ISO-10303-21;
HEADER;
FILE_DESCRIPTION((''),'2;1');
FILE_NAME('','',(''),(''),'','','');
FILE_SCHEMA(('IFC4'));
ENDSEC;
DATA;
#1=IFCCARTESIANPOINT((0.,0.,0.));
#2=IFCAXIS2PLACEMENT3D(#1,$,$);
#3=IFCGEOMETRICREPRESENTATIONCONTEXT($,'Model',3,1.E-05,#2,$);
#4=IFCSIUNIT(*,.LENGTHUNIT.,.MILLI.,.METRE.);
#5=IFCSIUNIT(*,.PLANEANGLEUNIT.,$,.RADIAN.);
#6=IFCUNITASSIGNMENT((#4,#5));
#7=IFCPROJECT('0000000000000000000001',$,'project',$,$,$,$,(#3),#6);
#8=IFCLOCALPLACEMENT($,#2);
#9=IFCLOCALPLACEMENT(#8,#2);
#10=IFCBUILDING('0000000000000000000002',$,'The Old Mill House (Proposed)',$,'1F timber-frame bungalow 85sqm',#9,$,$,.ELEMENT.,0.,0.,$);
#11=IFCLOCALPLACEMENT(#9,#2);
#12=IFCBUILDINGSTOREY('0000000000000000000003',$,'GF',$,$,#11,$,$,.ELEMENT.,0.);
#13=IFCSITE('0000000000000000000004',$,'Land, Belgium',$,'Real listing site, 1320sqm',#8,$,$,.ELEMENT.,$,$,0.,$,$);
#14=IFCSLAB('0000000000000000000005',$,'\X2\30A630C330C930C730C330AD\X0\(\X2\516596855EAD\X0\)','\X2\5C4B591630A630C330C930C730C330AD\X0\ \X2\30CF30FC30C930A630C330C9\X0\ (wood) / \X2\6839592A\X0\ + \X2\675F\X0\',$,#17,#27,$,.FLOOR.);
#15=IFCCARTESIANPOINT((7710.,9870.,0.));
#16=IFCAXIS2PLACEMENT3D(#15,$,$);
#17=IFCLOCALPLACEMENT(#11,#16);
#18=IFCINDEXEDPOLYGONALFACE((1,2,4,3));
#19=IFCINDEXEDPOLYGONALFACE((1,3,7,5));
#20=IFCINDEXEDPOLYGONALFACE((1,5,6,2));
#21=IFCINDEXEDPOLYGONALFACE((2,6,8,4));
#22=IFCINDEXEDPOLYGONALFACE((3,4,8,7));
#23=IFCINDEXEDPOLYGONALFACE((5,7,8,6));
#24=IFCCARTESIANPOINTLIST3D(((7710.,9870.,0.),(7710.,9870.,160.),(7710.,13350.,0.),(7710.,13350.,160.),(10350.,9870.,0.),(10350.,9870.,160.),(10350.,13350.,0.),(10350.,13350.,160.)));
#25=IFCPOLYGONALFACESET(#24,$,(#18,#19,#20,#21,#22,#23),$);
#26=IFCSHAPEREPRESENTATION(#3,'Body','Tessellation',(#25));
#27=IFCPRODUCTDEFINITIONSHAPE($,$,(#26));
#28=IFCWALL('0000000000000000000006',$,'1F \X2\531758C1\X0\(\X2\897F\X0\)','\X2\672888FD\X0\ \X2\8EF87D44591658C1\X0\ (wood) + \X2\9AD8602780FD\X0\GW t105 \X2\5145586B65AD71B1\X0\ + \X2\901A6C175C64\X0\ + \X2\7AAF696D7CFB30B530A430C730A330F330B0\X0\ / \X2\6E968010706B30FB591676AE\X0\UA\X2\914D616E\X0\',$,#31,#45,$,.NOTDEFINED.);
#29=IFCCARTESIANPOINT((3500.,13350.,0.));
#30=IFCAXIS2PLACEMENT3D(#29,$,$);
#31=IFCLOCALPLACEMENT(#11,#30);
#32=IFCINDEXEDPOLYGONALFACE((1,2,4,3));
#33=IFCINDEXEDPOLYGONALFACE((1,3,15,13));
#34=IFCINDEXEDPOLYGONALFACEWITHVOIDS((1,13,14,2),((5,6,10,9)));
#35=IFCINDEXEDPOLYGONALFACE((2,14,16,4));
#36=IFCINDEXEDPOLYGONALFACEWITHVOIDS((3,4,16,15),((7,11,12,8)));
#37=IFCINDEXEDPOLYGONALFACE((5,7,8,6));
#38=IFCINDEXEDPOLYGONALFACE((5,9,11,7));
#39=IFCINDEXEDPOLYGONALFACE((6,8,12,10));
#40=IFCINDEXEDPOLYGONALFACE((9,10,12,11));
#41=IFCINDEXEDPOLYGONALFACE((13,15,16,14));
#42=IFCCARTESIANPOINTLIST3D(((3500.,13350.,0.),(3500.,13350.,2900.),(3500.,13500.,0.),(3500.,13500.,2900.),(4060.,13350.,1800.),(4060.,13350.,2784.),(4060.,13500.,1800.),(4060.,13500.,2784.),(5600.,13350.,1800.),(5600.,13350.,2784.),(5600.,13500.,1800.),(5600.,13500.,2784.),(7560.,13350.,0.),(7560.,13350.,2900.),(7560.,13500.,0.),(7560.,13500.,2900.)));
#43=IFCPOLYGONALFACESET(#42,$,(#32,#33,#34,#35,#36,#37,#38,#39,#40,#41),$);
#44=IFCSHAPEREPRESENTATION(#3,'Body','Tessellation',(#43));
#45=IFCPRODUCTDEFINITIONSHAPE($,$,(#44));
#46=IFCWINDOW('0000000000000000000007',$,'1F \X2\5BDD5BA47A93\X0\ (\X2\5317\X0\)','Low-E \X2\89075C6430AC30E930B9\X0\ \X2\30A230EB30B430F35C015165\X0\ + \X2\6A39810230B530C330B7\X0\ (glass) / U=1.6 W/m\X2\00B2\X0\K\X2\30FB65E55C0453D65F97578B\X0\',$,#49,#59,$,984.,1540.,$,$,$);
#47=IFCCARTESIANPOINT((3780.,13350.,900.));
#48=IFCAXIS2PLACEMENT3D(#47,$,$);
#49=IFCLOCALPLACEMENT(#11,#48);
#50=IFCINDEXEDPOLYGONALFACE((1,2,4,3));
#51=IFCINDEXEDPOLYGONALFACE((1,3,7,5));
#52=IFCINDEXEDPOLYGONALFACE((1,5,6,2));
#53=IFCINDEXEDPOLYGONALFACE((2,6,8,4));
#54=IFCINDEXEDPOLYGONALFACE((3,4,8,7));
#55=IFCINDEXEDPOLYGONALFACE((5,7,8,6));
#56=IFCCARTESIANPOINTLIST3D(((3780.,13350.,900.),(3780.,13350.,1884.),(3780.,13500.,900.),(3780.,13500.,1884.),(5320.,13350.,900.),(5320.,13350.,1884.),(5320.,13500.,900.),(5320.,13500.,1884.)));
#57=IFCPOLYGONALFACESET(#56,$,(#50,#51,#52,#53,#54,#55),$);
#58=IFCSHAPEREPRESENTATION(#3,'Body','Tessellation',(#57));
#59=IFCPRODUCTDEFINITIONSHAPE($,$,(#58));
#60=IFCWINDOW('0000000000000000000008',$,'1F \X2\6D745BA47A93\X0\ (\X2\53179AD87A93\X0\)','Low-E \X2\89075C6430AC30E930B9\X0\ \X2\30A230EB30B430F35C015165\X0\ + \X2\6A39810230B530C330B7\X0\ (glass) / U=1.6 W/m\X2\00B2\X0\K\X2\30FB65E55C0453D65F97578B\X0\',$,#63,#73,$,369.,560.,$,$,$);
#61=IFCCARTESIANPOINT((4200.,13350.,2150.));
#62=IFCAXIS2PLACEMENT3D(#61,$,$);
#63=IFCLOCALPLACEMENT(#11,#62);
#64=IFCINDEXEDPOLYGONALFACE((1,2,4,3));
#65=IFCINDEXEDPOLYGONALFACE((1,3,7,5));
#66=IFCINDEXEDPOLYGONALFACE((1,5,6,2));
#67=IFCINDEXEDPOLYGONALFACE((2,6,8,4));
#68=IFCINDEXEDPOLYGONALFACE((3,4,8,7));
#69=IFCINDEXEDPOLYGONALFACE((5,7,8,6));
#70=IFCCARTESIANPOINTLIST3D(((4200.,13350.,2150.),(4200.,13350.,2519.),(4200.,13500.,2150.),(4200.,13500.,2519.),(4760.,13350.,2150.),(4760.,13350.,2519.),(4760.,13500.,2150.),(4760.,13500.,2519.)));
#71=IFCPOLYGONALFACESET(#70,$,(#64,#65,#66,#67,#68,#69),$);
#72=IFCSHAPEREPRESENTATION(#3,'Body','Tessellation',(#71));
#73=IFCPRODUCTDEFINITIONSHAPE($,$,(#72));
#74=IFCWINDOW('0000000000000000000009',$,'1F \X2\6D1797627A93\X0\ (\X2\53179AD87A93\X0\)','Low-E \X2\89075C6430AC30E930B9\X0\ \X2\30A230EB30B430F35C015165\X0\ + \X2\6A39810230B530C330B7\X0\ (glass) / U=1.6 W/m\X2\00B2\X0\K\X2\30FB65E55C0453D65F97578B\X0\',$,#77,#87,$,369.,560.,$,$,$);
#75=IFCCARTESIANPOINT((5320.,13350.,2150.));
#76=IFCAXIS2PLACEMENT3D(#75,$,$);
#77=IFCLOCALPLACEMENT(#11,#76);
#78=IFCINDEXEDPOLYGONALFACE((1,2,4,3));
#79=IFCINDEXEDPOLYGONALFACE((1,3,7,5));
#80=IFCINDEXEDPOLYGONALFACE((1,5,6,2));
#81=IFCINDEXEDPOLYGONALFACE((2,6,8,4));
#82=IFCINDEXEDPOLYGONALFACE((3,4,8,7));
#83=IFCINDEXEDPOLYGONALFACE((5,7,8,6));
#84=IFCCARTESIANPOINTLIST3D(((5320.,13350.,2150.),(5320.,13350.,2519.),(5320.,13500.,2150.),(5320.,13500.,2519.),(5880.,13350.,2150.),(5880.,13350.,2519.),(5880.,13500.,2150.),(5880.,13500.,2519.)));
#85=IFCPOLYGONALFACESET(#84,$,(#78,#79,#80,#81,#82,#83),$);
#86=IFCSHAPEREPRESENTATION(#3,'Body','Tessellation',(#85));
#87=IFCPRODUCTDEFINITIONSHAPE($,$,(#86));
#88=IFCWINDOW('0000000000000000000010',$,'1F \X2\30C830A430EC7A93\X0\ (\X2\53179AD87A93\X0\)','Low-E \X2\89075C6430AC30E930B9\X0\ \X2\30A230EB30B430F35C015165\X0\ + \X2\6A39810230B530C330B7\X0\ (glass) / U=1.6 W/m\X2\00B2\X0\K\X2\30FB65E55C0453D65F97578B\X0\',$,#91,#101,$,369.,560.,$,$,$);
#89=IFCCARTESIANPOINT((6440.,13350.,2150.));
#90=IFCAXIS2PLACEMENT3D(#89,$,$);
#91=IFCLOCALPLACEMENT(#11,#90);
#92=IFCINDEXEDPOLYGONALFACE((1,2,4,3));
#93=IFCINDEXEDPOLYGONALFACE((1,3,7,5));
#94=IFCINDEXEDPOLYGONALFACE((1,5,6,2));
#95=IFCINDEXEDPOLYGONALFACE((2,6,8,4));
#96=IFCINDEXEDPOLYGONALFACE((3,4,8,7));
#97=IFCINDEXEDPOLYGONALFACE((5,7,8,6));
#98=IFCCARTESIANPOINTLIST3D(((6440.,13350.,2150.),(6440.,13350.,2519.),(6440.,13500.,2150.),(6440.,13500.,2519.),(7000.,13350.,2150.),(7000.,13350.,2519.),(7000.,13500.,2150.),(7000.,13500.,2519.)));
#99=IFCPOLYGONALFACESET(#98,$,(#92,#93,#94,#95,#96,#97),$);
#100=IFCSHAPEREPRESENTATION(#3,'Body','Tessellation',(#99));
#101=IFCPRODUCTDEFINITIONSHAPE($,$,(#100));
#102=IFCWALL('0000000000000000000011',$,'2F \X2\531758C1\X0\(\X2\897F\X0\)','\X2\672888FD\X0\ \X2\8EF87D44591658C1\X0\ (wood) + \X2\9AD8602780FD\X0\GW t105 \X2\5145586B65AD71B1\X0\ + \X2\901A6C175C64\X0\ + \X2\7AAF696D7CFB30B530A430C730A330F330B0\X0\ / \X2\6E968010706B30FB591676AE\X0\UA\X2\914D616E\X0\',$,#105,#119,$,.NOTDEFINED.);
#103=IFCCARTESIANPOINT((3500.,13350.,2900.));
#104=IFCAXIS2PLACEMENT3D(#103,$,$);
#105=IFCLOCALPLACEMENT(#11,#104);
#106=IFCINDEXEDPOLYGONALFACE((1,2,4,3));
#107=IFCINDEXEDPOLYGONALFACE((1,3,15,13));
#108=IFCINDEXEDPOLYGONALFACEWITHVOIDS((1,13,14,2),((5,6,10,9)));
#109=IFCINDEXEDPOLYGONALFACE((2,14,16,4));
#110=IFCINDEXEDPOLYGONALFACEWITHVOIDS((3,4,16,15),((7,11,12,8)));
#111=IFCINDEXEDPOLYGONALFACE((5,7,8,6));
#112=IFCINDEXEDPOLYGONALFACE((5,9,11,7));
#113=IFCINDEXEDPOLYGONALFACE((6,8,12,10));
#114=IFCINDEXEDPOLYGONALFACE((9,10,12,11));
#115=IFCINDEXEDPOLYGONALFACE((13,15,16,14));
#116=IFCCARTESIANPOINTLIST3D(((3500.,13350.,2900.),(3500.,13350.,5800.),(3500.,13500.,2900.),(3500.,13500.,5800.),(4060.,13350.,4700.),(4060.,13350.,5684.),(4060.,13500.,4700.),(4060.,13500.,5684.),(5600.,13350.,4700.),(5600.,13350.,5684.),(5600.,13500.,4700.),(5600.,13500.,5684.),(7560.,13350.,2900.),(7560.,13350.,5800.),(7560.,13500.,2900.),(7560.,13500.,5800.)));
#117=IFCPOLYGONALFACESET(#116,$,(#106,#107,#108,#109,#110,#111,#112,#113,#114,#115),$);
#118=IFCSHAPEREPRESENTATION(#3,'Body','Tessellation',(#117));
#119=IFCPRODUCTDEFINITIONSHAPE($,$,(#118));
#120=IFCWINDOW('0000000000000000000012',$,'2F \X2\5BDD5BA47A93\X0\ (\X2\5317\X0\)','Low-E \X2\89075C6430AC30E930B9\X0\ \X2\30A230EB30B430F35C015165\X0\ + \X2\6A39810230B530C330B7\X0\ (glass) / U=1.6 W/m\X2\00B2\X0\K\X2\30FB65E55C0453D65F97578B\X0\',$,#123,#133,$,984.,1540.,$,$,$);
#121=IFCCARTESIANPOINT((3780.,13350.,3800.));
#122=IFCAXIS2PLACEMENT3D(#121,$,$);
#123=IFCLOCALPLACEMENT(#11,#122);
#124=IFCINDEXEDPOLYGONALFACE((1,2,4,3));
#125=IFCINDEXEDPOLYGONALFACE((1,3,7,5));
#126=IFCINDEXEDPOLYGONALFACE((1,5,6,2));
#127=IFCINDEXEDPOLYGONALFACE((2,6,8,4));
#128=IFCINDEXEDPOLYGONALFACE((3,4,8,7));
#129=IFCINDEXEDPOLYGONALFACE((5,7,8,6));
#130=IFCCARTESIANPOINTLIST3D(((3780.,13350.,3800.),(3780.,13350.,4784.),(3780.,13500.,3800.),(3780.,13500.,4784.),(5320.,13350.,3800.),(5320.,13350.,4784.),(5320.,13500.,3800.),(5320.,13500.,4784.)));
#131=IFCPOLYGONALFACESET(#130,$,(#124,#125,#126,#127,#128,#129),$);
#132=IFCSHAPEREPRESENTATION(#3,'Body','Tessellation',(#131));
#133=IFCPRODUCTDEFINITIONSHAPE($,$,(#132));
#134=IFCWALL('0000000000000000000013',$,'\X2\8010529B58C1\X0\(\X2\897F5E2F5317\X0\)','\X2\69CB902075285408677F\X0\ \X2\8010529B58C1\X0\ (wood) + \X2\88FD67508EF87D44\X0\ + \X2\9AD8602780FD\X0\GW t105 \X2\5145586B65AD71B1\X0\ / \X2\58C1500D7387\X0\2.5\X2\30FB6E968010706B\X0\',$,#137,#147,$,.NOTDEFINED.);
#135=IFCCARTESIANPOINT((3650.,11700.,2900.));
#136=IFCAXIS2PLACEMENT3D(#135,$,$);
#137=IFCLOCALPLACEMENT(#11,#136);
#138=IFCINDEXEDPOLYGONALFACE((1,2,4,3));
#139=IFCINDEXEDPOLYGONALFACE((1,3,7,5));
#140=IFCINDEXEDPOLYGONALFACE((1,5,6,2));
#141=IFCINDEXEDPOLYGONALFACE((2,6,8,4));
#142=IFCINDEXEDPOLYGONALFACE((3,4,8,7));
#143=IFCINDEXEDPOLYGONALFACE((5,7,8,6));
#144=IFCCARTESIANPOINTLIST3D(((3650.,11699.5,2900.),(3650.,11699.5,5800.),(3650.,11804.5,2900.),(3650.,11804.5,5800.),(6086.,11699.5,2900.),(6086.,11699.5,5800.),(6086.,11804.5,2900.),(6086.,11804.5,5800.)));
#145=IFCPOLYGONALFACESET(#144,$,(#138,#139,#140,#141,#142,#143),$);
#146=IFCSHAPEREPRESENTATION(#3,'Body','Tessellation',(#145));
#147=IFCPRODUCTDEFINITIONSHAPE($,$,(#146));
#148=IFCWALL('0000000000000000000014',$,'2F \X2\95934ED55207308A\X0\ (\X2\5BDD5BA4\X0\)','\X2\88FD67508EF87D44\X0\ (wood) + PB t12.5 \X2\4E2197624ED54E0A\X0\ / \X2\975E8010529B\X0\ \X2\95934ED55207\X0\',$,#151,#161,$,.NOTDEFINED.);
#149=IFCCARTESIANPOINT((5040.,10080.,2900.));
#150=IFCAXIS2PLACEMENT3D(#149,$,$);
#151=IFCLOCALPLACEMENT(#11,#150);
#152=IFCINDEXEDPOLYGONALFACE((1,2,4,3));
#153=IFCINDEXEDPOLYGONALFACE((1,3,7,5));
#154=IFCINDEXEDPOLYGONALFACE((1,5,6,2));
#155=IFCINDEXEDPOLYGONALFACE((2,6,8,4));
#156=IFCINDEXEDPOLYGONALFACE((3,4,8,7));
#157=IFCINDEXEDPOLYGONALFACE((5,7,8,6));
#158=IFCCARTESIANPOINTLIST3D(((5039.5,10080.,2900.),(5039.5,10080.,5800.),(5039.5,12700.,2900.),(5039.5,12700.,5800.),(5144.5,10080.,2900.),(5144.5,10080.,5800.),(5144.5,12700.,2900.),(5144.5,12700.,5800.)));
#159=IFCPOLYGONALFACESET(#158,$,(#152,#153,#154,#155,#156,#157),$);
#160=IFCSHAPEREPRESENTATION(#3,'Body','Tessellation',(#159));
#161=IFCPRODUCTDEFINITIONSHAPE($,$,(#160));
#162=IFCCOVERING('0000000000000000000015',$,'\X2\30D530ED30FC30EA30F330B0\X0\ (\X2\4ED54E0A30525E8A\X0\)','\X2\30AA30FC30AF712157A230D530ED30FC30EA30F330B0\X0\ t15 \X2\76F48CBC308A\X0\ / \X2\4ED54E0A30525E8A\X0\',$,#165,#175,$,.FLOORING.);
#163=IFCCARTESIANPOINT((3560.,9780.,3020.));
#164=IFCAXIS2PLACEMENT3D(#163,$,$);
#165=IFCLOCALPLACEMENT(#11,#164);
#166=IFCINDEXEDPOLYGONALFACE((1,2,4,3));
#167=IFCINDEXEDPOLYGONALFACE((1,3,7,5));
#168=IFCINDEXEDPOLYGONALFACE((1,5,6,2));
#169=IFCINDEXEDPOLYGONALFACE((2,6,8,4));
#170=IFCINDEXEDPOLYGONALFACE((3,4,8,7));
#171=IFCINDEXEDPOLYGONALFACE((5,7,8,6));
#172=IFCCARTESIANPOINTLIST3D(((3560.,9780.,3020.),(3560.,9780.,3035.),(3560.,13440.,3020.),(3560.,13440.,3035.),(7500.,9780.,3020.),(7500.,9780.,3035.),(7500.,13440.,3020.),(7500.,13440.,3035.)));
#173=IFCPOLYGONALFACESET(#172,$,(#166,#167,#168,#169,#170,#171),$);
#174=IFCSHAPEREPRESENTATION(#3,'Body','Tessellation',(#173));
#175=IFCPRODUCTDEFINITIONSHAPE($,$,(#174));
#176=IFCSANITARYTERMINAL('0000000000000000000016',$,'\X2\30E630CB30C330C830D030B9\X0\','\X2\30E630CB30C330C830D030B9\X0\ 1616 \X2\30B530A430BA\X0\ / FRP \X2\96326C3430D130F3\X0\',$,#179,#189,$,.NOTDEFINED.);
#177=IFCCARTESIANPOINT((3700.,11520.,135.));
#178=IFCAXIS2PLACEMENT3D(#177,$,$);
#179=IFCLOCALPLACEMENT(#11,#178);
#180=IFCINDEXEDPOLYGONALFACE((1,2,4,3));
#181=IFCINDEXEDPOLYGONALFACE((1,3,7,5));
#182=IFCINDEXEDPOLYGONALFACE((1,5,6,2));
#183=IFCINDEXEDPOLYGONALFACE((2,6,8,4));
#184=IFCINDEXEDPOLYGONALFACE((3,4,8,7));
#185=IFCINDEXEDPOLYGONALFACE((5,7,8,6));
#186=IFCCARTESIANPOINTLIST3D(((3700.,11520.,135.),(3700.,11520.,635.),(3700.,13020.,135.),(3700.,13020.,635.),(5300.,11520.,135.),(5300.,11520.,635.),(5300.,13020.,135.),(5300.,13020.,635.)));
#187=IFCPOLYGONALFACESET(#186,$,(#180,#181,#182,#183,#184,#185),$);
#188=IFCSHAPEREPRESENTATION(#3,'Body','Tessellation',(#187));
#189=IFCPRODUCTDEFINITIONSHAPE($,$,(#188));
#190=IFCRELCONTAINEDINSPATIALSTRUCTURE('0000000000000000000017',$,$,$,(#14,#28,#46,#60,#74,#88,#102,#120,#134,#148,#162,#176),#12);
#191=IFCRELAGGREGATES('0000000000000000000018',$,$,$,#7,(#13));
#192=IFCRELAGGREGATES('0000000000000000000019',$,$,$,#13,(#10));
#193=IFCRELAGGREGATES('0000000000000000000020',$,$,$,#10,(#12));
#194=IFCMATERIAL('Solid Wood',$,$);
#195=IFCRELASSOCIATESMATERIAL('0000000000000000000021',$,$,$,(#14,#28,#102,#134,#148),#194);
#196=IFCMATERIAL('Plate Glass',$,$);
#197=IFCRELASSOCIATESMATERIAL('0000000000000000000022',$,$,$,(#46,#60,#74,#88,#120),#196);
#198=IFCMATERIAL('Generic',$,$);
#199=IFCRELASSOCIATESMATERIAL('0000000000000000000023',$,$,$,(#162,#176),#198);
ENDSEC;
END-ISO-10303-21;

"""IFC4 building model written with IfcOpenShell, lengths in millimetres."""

from ifc_helpers import new_model, si_unit, frame, frame_2d, origin, place, context, project, spatial, rectangle, extrude, material, element, fill, save


model = new_model("IFC4")

# Units and contexts
model_context = context("Model", 3, precision=1e-05, world=origin())
ifc_project = project(units=[si_unit("LENGTHUNIT", "METRE", prefix="MILLI"), si_unit("PLANEANGLEUNIT", "RADIAN")], contexts=[model_context])

# Site, building, storey
site_placement = place(None, origin())
site = spatial("IfcSite", under=ifc_project, at=site_placement, Name="Land, Belgium", ObjectType="Real listing site, 1320sqm", CompositionType="ELEMENT", RefElevation=0.0)
building_placement = place(site_placement, origin())
building = spatial("IfcBuilding", under=site, at=building_placement, Name="The Old Mill House (Proposed)", ObjectType="1F timber-frame bungalow 85sqm", CompositionType="ELEMENT", ElevationOfRefHeight=0.0, ElevationOfTerrain=0.0)
storey_placement = place(building_placement, origin())
storey = spatial("IfcBuildingStorey", under=building, at=storey_placement, Name="GF", CompositionType="ELEMENT", Elevation=0.0)

# Slab
ifc_material_1 = material(Name="Solid Wood")
slab_placement = place(storey_placement, frame((7710.0, 9870.0, 0.0)))
element("IfcSlab", 1, at=slab_placement, inside=storey, material=ifc_material_1, Name="ウッドデッキ(入隅庭)", Description="屋外ウッドデッキ ハードウッド (wood) / 根太 + 束", PredefinedType="FLOOR", context=model_context, shape_type="SweptSolid", body=[
    extrude(rectangle(XDim=2640.0, YDim=3480.0, at=frame_2d((1320.0, 1740.0))), frame((7710.0, 9870.0, 0.0)), (0.0, 0.0, 1.0), 160.0),
])

# Wall, openings, windows
wall_1_placement = place(storey_placement, frame((3500.0, 13350.0, 0.0)))
wall_1 = element("IfcWall", 2, at=wall_1_placement, inside=storey, material=ifc_material_1, Name="1F 北壁(西)", Description="木製 軸組外壁 (wood) + 高性能GW t105 充填断熱 + 通気層 + 窯業系サイディング / 準耐火・外皮UA配慮", PredefinedType="NOTDEFINED", context=model_context, shape_type="SweptSolid", body=[
    extrude(rectangle(XDim=4060.0, YDim=150.0, at=frame_2d((2030.0, 75.0))), frame((3500.0, 13350.0, 0.0)), (0.0, 0.0, 1.0), 2900.0),
])
opening_1_placement = place(storey_placement, frame((3780.0, 13350.0, 900.0)))
opening_1 = element("IfcOpeningElement", 3, at=opening_1_placement, cuts=wall_1, PredefinedType="NOTDEFINED", context=model_context, shape_type="SweptSolid", body=[
    extrude(rectangle(XDim=1540.0, YDim=150.0, at=frame_2d((770.0, 75.0))), frame((3780.0, 13350.0, 900.0)), (0.0, 0.0, 1.0), 984.0),
])
opening_2_placement = place(storey_placement, frame((4200.0, 13350.0, 2150.0)))
opening_2 = element("IfcOpeningElement", 4, at=opening_2_placement, cuts=wall_1, PredefinedType="NOTDEFINED", context=model_context, shape_type="SweptSolid", body=[
    extrude(rectangle(XDim=560.0, YDim=150.0, at=frame_2d((280.0, 75.0))), frame((4200.0, 13350.0, 2150.0)), (0.0, 0.0, 1.0), 369.0),
])
opening_3_placement = place(storey_placement, frame((5320.0, 13350.0, 2150.0)))
opening_3 = element("IfcOpeningElement", 5, at=opening_3_placement, cuts=wall_1, PredefinedType="NOTDEFINED", context=model_context, shape_type="SweptSolid", body=[
    extrude(rectangle(XDim=560.0, YDim=150.0, at=frame_2d((280.0, 75.0))), frame((5320.0, 13350.0, 2150.0)), (0.0, 0.0, 1.0), 369.0),
])
opening_4_placement = place(storey_placement, frame((6440.0, 13350.0, 2150.0)))
opening_4 = element("IfcOpeningElement", 6, at=opening_4_placement, cuts=wall_1, PredefinedType="NOTDEFINED", context=model_context, shape_type="SweptSolid", body=[
    extrude(rectangle(XDim=560.0, YDim=150.0, at=frame_2d((280.0, 75.0))), frame((6440.0, 13350.0, 2150.0)), (0.0, 0.0, 1.0), 369.0),
])
ifc_material_2 = material(Name="Plate Glass")
window_1_placement = place(storey_placement, frame((3780.0, 13350.0, 900.0)))
window_1 = element("IfcWindow", 7, at=window_1_placement, inside=storey, material=ifc_material_2, Name="1F 寝室窓 (北)", Description="Low-E 複層ガラス アルゴン封入 + 樹脂サッシ (glass) / U=1.6 W/m²K・日射取得型", OverallHeight=984.0, OverallWidth=1540.0, context=model_context, shape_type="SweptSolid", body=[
    extrude(rectangle(XDim=1540.0, YDim=150.0, at=frame_2d((770.0, 75.0))), frame((3780.0, 13350.0, 900.0)), (0.0, 0.0, 1.0), 984.0),
])
fill(opening_1, window_1)
window_2_placement = place(storey_placement, frame((4200.0, 13350.0, 2150.0)))
window_2 = element("IfcWindow", 8, at=window_2_placement, inside=storey, material=ifc_material_2, Name="1F 浴室窓 (北高窓)", Description="Low-E 複層ガラス アルゴン封入 + 樹脂サッシ (glass) / U=1.6 W/m²K・日射取得型", OverallHeight=369.0, OverallWidth=560.0, context=model_context, shape_type="SweptSolid", body=[
    extrude(rectangle(XDim=560.0, YDim=150.0, at=frame_2d((280.0, 75.0))), frame((4200.0, 13350.0, 2150.0)), (0.0, 0.0, 1.0), 369.0),
])
fill(opening_2, window_2)
window_3_placement = place(storey_placement, frame((5320.0, 13350.0, 2150.0)))
window_3 = element("IfcWindow", 9, at=window_3_placement, inside=storey, material=ifc_material_2, Name="1F 洗面窓 (北高窓)", Description="Low-E 複層ガラス アルゴン封入 + 樹脂サッシ (glass) / U=1.6 W/m²K・日射取得型", OverallHeight=369.0, OverallWidth=560.0, context=model_context, shape_type="SweptSolid", body=[
    extrude(rectangle(XDim=560.0, YDim=150.0, at=frame_2d((280.0, 75.0))), frame((5320.0, 13350.0, 2150.0)), (0.0, 0.0, 1.0), 369.0),
])
fill(opening_3, window_3)
window_4_placement = place(storey_placement, frame((6440.0, 13350.0, 2150.0)))
window_4 = element("IfcWindow", 10, at=window_4_placement, inside=storey, material=ifc_material_2, Name="1F トイレ窓 (北高窓)", Description="Low-E 複層ガラス アルゴン封入 + 樹脂サッシ (glass) / U=1.6 W/m²K・日射取得型", OverallHeight=369.0, OverallWidth=560.0, context=model_context, shape_type="SweptSolid", body=[
    extrude(rectangle(XDim=560.0, YDim=150.0, at=frame_2d((280.0, 75.0))), frame((6440.0, 13350.0, 2150.0)), (0.0, 0.0, 1.0), 369.0),
])
fill(opening_4, window_4)

# Wall, opening, window
wall_2_placement = place(storey_placement, frame((3500.0, 13350.0, 2900.0)))
wall_2 = element("IfcWall", 11, at=wall_2_placement, inside=storey, material=ifc_material_1, Name="2F 北壁(西)", Description="木製 軸組外壁 (wood) + 高性能GW t105 充填断熱 + 通気層 + 窯業系サイディング / 準耐火・外皮UA配慮", PredefinedType="NOTDEFINED", context=model_context, shape_type="SweptSolid", body=[
    extrude(rectangle(XDim=4060.0, YDim=150.0, at=frame_2d((2030.0, 75.0))), frame((3500.0, 13350.0, 2900.0)), (0.0, 0.0, 1.0), 2900.0),
])
opening_5_placement = place(storey_placement, frame((3780.0, 13350.0, 3800.0)))
opening_5 = element("IfcOpeningElement", 12, at=opening_5_placement, cuts=wall_2, PredefinedType="NOTDEFINED", context=model_context, shape_type="SweptSolid", body=[
    extrude(rectangle(XDim=1540.0, YDim=150.0, at=frame_2d((770.0, 75.0))), frame((3780.0, 13350.0, 3800.0)), (0.0, 0.0, 1.0), 984.0),
])
window_5_placement = place(storey_placement, frame((3780.0, 13350.0, 3800.0)))
window_5 = element("IfcWindow", 13, at=window_5_placement, inside=storey, material=ifc_material_2, Name="2F 寝室窓 (北)", Description="Low-E 複層ガラス アルゴン封入 + 樹脂サッシ (glass) / U=1.6 W/m²K・日射取得型", OverallHeight=984.0, OverallWidth=1540.0, context=model_context, shape_type="SweptSolid", body=[
    extrude(rectangle(XDim=1540.0, YDim=150.0, at=frame_2d((770.0, 75.0))), frame((3780.0, 13350.0, 3800.0)), (0.0, 0.0, 1.0), 984.0),
])
fill(opening_5, window_5)

# Walls
wall_3_placement = place(storey_placement, frame((3650.0, 11700.0, 2900.0)))
element("IfcWall", 14, at=wall_3_placement, inside=storey, material=ifc_material_1, Name="耐力壁(西帯北)", Description="構造用合板 耐力壁 (wood) + 製材軸組 + 高性能GW t105 充填断熱 / 壁倍率2.5・準耐火", PredefinedType="NOTDEFINED", context=model_context, shape_type="SweptSolid", body=[
    extrude(rectangle(XDim=2436.0, YDim=105.0, at=frame_2d((1218.0, 52.0))), frame((3650.0, 11700.0, 2900.0)), (0.0, 0.0, 1.0), 2900.0),
])
wall_4_placement = place(storey_placement, frame((5040.0, 10080.0, 2900.0)))
element("IfcWall", 15, at=wall_4_placement, inside=storey, material=ifc_material_1, Name="2F 間仕切り (寝室)", Description="製材軸組 (wood) + PB t12.5 両面仕上 / 非耐力 間仕切", PredefinedType="NOTDEFINED", context=model_context, shape_type="SweptSolid", body=[
    extrude(rectangle(XDim=105.0, YDim=2620.0, at=frame_2d((52.0, 1310.0))), frame((5040.0, 10080.0, 2900.0)), (0.0, 0.0, 1.0), 2900.0),
])

# Covering
ifc_material_3 = material(Name="Generic")
covering_placement = place(storey_placement, frame((3560.0, 9780.0, 3020.0)))
element("IfcCovering", 16, at=covering_placement, inside=storey, material=ifc_material_3, Name="フローリング (仕上げ床)", Description="オーク無垢フローリング t15 直貼り / 仕上げ床", PredefinedType="FLOORING", context=model_context, shape_type="SweptSolid", body=[
    extrude(rectangle(XDim=3940.0, YDim=3660.0, at=frame_2d((1970.0, 1830.0))), frame((3560.0, 9780.0, 3020.0)), (0.0, 0.0, 1.0), 15.0),
])

# Sanitary terminal
sanitary_terminal_1_placement = place(storey_placement, frame((3700.0, 11520.0, 135.0)))
element("IfcSanitaryTerminal", 17, at=sanitary_terminal_1_placement, inside=storey, material=ifc_material_3, Name="ユニットバス", Description="ユニットバス 1616 サイズ / FRP 防水パン", PredefinedType="NOTDEFINED", context=model_context, shape_type="SweptSolid", body=[
    extrude(rectangle(XDim=1600.0, YDim=1500.0, at=frame_2d((800.0, 750.0))), frame((3700.0, 11520.0, 135.0)), (0.0, 0.0, 1.0), 500.0),
])

save(model, "model.ifc")
